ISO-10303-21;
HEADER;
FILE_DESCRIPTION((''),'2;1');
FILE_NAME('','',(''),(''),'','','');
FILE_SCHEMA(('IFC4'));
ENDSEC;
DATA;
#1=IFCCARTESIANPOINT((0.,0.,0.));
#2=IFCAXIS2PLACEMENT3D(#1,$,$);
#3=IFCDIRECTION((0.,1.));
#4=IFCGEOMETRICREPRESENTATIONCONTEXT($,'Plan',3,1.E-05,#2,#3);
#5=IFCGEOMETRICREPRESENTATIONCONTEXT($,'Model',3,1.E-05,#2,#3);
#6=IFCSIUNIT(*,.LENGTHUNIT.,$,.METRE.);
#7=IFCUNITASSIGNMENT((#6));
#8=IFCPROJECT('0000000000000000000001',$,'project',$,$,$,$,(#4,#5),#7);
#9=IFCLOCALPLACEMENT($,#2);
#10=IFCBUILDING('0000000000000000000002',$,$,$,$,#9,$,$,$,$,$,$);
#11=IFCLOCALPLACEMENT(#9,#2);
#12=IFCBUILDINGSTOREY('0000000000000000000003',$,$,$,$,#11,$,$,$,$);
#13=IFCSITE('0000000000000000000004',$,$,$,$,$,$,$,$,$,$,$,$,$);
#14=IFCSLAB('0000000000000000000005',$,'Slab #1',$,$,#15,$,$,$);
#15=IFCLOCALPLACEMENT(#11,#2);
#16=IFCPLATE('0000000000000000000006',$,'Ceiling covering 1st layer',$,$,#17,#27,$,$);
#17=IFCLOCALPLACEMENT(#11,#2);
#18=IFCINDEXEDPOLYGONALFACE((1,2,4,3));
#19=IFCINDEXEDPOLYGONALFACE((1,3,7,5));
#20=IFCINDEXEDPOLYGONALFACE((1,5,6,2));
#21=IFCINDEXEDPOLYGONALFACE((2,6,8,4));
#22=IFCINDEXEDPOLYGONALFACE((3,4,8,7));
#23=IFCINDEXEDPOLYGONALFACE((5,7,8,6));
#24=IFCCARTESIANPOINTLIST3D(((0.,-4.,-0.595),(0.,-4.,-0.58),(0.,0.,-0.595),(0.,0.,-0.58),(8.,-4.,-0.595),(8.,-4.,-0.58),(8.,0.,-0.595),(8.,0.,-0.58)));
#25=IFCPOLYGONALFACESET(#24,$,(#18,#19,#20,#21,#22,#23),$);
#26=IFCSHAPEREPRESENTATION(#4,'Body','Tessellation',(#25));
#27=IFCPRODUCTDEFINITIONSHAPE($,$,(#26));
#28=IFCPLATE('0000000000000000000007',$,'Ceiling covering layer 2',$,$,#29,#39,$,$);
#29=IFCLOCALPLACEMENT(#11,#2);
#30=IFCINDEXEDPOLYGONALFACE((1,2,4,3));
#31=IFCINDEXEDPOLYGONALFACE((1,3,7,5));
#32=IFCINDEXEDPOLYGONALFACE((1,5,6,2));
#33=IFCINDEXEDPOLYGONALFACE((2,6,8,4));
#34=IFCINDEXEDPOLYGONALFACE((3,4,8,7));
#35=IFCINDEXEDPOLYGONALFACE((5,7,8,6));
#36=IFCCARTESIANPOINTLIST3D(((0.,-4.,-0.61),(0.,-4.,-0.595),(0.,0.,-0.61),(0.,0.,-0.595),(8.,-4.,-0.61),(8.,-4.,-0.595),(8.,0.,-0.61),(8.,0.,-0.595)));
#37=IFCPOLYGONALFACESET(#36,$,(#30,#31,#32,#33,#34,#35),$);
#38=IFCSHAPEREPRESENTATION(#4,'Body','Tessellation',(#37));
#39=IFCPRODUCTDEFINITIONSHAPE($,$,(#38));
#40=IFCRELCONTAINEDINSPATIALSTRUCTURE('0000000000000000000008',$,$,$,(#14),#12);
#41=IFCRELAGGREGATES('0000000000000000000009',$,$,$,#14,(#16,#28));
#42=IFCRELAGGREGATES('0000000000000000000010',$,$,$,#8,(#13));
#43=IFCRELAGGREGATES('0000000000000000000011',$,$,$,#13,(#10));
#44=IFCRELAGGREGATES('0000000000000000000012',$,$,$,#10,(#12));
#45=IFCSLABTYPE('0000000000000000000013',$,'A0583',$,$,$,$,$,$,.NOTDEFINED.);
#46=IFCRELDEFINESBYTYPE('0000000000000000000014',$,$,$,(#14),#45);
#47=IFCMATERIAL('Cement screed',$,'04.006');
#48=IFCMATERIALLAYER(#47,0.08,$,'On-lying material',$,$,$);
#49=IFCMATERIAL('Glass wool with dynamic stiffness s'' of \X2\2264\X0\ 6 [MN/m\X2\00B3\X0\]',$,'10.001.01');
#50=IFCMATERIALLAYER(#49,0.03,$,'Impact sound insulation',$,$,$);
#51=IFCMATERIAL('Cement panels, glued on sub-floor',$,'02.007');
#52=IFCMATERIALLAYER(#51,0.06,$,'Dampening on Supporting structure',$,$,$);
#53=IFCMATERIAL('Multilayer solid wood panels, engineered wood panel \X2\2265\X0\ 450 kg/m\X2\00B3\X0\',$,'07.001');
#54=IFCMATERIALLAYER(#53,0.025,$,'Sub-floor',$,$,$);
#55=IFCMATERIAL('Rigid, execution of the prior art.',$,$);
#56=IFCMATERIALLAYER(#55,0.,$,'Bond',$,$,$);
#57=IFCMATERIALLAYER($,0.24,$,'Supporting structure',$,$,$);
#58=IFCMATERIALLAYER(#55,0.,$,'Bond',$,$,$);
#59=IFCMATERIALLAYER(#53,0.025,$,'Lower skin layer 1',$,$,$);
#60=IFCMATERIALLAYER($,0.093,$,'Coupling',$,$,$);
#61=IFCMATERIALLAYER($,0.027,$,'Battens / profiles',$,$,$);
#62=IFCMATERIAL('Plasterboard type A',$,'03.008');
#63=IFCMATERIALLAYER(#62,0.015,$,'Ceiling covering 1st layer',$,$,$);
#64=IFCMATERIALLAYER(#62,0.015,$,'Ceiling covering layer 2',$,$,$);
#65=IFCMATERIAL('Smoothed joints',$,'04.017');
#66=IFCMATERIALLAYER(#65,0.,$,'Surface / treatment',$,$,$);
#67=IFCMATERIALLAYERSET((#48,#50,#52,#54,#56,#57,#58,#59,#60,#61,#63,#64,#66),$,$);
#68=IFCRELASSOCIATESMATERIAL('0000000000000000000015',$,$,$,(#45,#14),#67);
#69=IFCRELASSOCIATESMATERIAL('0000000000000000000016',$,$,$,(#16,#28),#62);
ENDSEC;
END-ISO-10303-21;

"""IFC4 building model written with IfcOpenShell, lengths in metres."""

from ifc_helpers import new_model, si_unit, direction, frame, frame_2d, origin, place, context, project, spatial, rectangle, extrude, material, layer, layer_set, type_object, element, aggregate, save


model = new_model("IFC4")

# Units and contexts
plan_context = context("Plan", 3, precision=1e-05, world=origin(), true_north=direction((0.0, 1.0)))
model_context = context("Model", 3, precision=1e-05, world=origin(), true_north=direction((0.0, 1.0)))
ifc_project = project(units=[si_unit("LENGTHUNIT", "METRE")], contexts=[plan_context, model_context])

# Site, building, storey
site = spatial("IfcSite", under=ifc_project)
building_placement = place(None, origin())
building = spatial("IfcBuilding", under=site, at=building_placement)
storey_placement = place(building_placement, origin())
storey = spatial("IfcBuildingStorey", under=building, at=storey_placement)

# Slab, plates
ifc_material_1 = material(Name="Cement screed", Category="04.006")
ifc_layer_1 = layer(ifc_material_1, 0.08, Name="On-lying material")
ifc_material_2 = material(Name="Glass wool with dynamic stiffness s' of ≤ 6 [MN/m³]", Category="10.001.01")
ifc_layer_2 = layer(ifc_material_2, 0.03, Name="Impact sound insulation")
ifc_material_3 = material(Name="Cement panels, glued on sub-floor", Category="02.007")
ifc_layer_3 = layer(ifc_material_3, 0.06, Name="Dampening on Supporting structure")
ifc_material_4 = material(Name="Multilayer solid wood panels, engineered wood panel ≥ 450 kg/m³", Category="07.001")
ifc_layer_4 = layer(ifc_material_4, 0.025, Name="Sub-floor")
ifc_material_5 = material(Name="Rigid, execution of the prior art.")
ifc_layer_5 = layer(ifc_material_5, 0.0, Name="Bond")
ifc_layer_6 = layer(None, 0.24, Name="Supporting structure")
ifc_layer_7 = layer(ifc_material_5, 0.0, Name="Bond")
ifc_layer_8 = layer(ifc_material_4, 0.025, Name="Lower skin layer 1")
ifc_layer_9 = layer(None, 0.093, Name="Coupling")
ifc_layer_10 = layer(None, 0.027, Name="Battens / profiles")
ifc_material_6 = material(Name="Plasterboard type A", Category="03.008")
ifc_layer_11 = layer(ifc_material_6, 0.015, Name="Ceiling covering 1st layer")
ifc_layer_12 = layer(ifc_material_6, 0.015, Name="Ceiling covering layer 2")
ifc_material_7 = material(Name="Smoothed joints", Category="04.017")
ifc_layer_13 = layer(ifc_material_7, 0.0, Name="Surface / treatment")
ifc_layer_set = layer_set([ifc_layer_1, ifc_layer_2, ifc_layer_3, ifc_layer_4, ifc_layer_5, ifc_layer_6, ifc_layer_7, ifc_layer_8, ifc_layer_9, ifc_layer_10, ifc_layer_11, ifc_layer_12, ifc_layer_13])
slab_type = type_object("IfcSlabType", Name="A0583", PredefinedType="NOTDEFINED", material=ifc_layer_set)
slab_placement = place(None, frame((0.0, 0.0, 0.0), z_axis=(0.0, 0.0, -1.0), x_axis=(1.0, 0.0, 0.0)))
slab = element("IfcSlab", 1, at=slab_placement, inside=storey, type_object=slab_type, material=ifc_layer_set, Name="Slab #1")
plate_1_placement = place(slab_placement, origin())
plate_1 = element("IfcPlate", 2, at=plate_1_placement, material=ifc_material_6, Name="Ceiling covering 1st layer", context=plan_context, shape_type="SweptSolid", body=[
    extrude(rectangle(XDim=8.0, YDim=4.0, at=frame_2d((4.0, 2.0), x_axis=(1.0, 0.0))), frame((0.0, 0.0, 0.58), z_axis=(0.0, 0.0, 1.0), x_axis=(1.0, 0.0, 0.0)), (0.0, 0.0, 1.0), 0.015),
])
plate_2_placement = place(slab_placement, origin())
plate_2 = element("IfcPlate", 3, at=plate_2_placement, material=ifc_material_6, Name="Ceiling covering layer 2", context=plan_context, shape_type="SweptSolid", body=[
    extrude(rectangle(XDim=8.0, YDim=4.0, at=frame_2d((4.0, 2.0), x_axis=(1.0, 0.0))), frame((0.0, 0.0, 0.595), z_axis=(0.0, 0.0, 1.0), x_axis=(1.0, 0.0, 0.0)), (0.0, 0.0, 1.0), 0.015),
])
aggregate(slab, [plate_1, plate_2])

save(model, "model.ifc")
